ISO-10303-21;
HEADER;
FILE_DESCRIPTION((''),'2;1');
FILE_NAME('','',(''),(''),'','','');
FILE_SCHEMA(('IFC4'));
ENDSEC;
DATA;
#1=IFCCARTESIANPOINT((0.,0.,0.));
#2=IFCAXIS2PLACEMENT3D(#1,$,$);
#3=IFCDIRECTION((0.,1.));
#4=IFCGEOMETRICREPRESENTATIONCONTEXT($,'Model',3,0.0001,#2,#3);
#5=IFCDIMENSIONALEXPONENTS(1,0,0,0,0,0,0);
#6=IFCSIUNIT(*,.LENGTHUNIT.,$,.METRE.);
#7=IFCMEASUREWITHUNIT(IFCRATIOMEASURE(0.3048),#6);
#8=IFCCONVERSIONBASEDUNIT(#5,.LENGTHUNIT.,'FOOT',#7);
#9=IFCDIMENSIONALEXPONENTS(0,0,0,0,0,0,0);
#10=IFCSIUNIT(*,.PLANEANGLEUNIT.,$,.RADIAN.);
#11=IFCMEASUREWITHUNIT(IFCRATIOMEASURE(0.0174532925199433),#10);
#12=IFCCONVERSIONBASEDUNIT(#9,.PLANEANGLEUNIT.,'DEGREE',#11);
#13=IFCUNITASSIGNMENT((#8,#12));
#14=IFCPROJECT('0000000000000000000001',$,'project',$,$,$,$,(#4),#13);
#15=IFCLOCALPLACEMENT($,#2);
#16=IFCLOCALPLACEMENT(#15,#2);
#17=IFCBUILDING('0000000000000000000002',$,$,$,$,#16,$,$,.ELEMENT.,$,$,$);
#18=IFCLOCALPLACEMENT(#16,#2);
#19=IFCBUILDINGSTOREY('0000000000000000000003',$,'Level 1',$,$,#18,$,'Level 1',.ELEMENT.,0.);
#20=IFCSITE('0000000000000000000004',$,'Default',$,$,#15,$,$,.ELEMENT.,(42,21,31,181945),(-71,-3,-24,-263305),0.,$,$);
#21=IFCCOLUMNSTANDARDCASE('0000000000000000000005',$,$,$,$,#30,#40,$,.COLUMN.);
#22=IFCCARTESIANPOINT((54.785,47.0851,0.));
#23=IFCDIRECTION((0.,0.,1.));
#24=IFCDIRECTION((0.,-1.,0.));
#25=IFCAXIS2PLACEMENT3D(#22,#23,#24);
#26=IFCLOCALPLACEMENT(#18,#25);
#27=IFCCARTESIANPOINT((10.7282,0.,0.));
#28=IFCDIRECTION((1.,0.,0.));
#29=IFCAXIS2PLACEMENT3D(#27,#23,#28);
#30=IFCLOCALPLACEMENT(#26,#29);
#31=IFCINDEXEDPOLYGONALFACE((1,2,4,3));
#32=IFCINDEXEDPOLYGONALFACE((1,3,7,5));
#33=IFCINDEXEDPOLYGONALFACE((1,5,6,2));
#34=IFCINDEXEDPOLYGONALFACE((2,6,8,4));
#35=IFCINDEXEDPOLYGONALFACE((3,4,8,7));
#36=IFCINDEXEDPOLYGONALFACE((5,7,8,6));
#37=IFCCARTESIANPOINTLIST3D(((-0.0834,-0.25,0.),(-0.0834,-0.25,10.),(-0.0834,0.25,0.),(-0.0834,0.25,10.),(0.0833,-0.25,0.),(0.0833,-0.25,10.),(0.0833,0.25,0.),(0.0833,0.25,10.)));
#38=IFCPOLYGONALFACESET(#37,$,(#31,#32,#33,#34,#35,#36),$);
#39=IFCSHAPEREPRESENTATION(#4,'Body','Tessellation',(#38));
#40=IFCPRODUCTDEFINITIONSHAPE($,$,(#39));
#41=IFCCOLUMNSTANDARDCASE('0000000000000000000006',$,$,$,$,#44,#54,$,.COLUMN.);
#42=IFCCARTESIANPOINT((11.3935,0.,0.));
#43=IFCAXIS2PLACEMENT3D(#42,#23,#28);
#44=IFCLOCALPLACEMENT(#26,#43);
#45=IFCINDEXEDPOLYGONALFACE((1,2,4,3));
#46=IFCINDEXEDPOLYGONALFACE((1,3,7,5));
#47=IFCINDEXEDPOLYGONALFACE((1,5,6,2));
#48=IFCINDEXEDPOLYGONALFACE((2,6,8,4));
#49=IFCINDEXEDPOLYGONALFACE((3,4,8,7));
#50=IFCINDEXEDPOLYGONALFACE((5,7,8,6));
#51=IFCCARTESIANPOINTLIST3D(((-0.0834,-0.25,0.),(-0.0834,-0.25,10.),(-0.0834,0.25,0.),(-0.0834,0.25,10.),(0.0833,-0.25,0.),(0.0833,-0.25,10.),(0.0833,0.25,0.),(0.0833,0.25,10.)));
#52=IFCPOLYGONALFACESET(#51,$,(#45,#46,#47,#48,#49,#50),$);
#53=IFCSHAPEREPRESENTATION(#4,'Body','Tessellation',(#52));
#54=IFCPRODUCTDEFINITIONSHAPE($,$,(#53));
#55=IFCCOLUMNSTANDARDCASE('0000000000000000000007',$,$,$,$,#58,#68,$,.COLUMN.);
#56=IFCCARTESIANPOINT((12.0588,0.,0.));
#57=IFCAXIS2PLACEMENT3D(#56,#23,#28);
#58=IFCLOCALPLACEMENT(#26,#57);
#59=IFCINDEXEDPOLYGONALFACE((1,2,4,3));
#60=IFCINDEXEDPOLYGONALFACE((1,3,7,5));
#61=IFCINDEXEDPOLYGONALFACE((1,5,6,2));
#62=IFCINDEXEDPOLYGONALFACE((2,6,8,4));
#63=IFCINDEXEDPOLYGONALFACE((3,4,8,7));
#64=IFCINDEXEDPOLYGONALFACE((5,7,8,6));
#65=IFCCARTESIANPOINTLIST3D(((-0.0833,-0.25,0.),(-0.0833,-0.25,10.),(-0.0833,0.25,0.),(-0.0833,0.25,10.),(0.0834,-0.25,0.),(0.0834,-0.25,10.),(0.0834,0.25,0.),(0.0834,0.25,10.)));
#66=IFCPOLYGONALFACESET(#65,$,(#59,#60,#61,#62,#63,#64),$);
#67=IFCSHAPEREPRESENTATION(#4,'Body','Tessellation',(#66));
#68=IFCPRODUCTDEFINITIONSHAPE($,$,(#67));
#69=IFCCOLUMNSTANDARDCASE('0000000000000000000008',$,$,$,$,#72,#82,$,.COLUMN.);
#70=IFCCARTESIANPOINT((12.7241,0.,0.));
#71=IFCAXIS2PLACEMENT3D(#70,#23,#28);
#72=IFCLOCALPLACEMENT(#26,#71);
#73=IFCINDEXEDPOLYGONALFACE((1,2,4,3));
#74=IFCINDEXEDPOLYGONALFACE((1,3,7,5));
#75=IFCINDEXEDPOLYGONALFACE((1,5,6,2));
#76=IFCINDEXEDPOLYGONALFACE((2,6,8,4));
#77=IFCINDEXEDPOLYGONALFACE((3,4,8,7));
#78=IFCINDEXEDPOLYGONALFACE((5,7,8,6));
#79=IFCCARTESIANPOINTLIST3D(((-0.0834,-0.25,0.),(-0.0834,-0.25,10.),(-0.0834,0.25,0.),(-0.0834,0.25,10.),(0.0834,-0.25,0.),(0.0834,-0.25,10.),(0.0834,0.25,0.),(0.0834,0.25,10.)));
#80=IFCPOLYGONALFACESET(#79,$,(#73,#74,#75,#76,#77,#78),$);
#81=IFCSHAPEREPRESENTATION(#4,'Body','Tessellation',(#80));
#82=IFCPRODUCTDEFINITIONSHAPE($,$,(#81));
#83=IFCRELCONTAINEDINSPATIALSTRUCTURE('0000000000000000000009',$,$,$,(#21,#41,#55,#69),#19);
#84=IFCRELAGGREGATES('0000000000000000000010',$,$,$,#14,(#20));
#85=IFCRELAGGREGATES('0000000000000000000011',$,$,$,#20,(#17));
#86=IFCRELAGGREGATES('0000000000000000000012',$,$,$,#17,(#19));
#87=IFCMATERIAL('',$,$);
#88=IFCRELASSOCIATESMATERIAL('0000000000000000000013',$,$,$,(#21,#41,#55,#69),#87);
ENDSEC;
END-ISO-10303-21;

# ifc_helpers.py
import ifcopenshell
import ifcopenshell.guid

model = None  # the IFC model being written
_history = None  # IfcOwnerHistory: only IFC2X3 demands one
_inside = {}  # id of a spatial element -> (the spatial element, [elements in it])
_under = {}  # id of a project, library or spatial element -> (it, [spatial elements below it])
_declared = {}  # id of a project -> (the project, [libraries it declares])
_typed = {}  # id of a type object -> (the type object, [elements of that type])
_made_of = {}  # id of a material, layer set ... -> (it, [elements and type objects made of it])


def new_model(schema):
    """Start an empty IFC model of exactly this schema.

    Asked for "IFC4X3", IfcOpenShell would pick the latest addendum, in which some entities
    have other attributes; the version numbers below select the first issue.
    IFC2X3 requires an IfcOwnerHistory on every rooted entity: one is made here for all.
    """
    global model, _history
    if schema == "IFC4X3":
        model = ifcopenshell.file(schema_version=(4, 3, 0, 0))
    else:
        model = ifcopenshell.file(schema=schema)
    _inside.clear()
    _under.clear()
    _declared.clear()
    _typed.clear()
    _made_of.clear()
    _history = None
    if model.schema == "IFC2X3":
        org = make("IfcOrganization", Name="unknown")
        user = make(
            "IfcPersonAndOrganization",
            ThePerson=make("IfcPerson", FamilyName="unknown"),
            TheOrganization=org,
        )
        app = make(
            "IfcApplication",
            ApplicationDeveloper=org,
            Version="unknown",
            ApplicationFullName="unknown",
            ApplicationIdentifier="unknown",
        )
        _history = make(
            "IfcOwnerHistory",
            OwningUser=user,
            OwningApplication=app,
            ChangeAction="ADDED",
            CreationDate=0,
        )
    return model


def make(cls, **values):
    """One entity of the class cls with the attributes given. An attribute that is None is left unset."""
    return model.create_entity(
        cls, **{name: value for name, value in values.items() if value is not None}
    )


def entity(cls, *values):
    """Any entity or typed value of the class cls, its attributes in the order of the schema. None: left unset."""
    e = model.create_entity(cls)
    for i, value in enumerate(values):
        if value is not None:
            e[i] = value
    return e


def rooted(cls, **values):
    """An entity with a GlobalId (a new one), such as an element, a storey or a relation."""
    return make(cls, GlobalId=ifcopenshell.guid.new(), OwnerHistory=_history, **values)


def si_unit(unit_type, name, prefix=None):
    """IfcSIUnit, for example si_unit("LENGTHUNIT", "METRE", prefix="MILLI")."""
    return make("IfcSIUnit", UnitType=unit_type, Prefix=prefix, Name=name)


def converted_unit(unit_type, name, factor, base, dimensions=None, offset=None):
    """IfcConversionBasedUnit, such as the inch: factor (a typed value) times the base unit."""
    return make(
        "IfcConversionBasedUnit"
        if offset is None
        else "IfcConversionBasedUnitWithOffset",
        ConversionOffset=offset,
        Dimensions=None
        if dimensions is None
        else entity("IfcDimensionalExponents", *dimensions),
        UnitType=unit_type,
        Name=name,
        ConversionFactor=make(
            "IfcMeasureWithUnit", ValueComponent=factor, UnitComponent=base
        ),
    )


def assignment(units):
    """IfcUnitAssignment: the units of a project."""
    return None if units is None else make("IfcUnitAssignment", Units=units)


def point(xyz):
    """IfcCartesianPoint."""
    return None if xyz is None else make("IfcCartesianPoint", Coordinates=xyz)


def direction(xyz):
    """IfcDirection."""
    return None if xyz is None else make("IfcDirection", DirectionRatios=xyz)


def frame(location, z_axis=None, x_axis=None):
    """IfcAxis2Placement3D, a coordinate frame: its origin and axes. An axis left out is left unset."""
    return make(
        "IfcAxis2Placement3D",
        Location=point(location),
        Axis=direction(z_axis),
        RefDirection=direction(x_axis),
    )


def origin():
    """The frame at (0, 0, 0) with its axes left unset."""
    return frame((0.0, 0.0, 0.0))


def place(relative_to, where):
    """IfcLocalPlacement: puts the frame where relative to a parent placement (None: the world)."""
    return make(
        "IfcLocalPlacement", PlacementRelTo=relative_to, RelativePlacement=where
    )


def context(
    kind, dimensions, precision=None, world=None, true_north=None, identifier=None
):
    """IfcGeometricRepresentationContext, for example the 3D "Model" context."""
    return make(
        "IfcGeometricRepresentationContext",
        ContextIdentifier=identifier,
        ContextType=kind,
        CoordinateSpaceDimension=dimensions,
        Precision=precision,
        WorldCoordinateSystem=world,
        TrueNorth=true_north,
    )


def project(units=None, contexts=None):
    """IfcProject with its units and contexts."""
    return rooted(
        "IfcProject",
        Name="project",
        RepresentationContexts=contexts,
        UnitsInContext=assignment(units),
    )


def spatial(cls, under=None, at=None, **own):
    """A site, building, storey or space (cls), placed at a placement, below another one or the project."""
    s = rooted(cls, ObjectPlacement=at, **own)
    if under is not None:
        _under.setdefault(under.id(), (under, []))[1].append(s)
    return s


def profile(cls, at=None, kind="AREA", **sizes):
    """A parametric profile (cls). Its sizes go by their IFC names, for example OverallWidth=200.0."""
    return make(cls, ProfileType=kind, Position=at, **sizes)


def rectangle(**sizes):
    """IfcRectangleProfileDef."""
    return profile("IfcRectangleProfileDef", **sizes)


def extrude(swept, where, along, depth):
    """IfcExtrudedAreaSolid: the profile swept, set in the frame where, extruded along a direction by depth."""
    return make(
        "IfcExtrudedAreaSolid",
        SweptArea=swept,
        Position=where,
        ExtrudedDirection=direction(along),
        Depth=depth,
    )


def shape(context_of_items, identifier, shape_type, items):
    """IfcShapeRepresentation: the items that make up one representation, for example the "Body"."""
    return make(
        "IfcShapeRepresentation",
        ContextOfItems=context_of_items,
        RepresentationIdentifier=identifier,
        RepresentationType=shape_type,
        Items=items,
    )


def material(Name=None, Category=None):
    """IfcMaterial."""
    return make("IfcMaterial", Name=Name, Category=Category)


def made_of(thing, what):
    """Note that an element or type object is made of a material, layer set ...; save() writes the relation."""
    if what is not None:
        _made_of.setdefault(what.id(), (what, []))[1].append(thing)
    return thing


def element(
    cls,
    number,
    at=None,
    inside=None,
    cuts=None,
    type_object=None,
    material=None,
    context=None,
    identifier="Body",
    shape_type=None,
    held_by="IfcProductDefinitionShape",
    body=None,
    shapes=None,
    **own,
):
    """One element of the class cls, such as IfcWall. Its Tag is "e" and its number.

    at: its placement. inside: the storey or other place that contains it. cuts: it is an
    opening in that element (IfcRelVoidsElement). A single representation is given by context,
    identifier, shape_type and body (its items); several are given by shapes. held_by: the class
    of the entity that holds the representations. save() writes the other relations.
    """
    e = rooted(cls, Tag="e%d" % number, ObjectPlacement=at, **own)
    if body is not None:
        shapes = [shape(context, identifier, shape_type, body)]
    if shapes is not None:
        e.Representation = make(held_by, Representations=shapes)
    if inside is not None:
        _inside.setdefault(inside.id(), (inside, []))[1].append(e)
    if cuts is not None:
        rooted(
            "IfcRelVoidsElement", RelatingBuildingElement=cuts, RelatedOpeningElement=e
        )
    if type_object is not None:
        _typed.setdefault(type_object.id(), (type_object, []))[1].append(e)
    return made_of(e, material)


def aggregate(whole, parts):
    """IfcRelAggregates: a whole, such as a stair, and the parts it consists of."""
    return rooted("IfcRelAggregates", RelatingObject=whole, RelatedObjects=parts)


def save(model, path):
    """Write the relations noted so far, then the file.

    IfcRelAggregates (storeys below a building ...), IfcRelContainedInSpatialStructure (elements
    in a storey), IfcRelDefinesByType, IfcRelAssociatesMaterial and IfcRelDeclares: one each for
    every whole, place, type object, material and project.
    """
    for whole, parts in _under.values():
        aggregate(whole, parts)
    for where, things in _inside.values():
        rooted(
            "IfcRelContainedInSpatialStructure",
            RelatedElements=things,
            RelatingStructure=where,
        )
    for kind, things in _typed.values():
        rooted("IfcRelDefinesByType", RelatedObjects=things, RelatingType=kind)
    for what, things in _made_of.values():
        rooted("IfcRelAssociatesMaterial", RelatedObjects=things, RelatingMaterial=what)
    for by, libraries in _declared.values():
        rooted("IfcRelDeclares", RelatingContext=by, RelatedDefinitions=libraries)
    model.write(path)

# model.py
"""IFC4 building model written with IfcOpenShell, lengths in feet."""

from ifc_helpers import new_model, entity, si_unit, converted_unit, direction, frame, origin, place, context, project, spatial, rectangle, extrude, material, element, save


model = new_model("IFC4")

# Units and contexts
model_context = context("Model", 3, precision=0.0001, world=origin(), true_north=direction((0.0, 1.0)))
ifc_project = project(units=[converted_unit("LENGTHUNIT", "FOOT", entity("IfcRatioMeasure", 0.3048), si_unit("LENGTHUNIT", "METRE"), dimensions=[1, 0, 0, 0, 0, 0, 0]), converted_unit("PLANEANGLEUNIT", "DEGREE", entity("IfcRatioMeasure", 0.0174532925199433), si_unit("PLANEANGLEUNIT", "RADIAN"), dimensions=[0, 0, 0, 0, 0, 0, 0])], contexts=[model_context])

# Site, building, storey
site_placement = place(None, origin())
site = spatial("IfcSite", under=ifc_project, at=site_placement, Name="Default", CompositionType="ELEMENT", RefLatitude=(42, 21, 31, 181945), RefLongitude=(-71, -3, -24, -263305), RefElevation=0.0)
building_placement = place(site_placement, origin())
building = spatial("IfcBuilding", under=site, at=building_placement, CompositionType="ELEMENT")
storey_placement = place(building_placement, origin())
storey = spatial("IfcBuildingStorey", under=building, at=storey_placement, Name="Level 1", LongName="Level 1", CompositionType="ELEMENT", Elevation=0.0)

# Columns
ifc_material_1 = material(Name="")
placement_1 = place(storey_placement, frame((54.785, 47.0851, 0.0), z_axis=(0.0, 0.0, 1.0), x_axis=(0.0, -1.0, 0.0)))
for number, where, z_axis, x_axis in (
    (1, (10.7282, 0.0, 0.0), (0.0, 0.0, 1.0), (1.0, 0.0, 0.0)),
    (2, (11.3935, 0.0, 0.0), (0.0, 0.0, 1.0), (1.0, 0.0, 0.0)),
    (3, (12.0588, 0.0, 0.0), (0.0, 0.0, 1.0), (1.0, 0.0, 0.0)),
    (4, (12.7241, 0.0, 0.0), (0.0, 0.0, 1.0), (1.0, 0.0, 0.0)),
):
    element("IfcColumnStandardCase", number, at=place(placement_1, frame(where, z_axis=z_axis, x_axis=x_axis)), inside=storey, material=ifc_material_1, PredefinedType="COLUMN", context=model_context, shape_type="SweptSolid", body=[
        extrude(rectangle(XDim=0.1667, YDim=0.5), origin(), (0.0, 0.0, 1.0), 10.0),
    ])

save(model, "model.ifc")
